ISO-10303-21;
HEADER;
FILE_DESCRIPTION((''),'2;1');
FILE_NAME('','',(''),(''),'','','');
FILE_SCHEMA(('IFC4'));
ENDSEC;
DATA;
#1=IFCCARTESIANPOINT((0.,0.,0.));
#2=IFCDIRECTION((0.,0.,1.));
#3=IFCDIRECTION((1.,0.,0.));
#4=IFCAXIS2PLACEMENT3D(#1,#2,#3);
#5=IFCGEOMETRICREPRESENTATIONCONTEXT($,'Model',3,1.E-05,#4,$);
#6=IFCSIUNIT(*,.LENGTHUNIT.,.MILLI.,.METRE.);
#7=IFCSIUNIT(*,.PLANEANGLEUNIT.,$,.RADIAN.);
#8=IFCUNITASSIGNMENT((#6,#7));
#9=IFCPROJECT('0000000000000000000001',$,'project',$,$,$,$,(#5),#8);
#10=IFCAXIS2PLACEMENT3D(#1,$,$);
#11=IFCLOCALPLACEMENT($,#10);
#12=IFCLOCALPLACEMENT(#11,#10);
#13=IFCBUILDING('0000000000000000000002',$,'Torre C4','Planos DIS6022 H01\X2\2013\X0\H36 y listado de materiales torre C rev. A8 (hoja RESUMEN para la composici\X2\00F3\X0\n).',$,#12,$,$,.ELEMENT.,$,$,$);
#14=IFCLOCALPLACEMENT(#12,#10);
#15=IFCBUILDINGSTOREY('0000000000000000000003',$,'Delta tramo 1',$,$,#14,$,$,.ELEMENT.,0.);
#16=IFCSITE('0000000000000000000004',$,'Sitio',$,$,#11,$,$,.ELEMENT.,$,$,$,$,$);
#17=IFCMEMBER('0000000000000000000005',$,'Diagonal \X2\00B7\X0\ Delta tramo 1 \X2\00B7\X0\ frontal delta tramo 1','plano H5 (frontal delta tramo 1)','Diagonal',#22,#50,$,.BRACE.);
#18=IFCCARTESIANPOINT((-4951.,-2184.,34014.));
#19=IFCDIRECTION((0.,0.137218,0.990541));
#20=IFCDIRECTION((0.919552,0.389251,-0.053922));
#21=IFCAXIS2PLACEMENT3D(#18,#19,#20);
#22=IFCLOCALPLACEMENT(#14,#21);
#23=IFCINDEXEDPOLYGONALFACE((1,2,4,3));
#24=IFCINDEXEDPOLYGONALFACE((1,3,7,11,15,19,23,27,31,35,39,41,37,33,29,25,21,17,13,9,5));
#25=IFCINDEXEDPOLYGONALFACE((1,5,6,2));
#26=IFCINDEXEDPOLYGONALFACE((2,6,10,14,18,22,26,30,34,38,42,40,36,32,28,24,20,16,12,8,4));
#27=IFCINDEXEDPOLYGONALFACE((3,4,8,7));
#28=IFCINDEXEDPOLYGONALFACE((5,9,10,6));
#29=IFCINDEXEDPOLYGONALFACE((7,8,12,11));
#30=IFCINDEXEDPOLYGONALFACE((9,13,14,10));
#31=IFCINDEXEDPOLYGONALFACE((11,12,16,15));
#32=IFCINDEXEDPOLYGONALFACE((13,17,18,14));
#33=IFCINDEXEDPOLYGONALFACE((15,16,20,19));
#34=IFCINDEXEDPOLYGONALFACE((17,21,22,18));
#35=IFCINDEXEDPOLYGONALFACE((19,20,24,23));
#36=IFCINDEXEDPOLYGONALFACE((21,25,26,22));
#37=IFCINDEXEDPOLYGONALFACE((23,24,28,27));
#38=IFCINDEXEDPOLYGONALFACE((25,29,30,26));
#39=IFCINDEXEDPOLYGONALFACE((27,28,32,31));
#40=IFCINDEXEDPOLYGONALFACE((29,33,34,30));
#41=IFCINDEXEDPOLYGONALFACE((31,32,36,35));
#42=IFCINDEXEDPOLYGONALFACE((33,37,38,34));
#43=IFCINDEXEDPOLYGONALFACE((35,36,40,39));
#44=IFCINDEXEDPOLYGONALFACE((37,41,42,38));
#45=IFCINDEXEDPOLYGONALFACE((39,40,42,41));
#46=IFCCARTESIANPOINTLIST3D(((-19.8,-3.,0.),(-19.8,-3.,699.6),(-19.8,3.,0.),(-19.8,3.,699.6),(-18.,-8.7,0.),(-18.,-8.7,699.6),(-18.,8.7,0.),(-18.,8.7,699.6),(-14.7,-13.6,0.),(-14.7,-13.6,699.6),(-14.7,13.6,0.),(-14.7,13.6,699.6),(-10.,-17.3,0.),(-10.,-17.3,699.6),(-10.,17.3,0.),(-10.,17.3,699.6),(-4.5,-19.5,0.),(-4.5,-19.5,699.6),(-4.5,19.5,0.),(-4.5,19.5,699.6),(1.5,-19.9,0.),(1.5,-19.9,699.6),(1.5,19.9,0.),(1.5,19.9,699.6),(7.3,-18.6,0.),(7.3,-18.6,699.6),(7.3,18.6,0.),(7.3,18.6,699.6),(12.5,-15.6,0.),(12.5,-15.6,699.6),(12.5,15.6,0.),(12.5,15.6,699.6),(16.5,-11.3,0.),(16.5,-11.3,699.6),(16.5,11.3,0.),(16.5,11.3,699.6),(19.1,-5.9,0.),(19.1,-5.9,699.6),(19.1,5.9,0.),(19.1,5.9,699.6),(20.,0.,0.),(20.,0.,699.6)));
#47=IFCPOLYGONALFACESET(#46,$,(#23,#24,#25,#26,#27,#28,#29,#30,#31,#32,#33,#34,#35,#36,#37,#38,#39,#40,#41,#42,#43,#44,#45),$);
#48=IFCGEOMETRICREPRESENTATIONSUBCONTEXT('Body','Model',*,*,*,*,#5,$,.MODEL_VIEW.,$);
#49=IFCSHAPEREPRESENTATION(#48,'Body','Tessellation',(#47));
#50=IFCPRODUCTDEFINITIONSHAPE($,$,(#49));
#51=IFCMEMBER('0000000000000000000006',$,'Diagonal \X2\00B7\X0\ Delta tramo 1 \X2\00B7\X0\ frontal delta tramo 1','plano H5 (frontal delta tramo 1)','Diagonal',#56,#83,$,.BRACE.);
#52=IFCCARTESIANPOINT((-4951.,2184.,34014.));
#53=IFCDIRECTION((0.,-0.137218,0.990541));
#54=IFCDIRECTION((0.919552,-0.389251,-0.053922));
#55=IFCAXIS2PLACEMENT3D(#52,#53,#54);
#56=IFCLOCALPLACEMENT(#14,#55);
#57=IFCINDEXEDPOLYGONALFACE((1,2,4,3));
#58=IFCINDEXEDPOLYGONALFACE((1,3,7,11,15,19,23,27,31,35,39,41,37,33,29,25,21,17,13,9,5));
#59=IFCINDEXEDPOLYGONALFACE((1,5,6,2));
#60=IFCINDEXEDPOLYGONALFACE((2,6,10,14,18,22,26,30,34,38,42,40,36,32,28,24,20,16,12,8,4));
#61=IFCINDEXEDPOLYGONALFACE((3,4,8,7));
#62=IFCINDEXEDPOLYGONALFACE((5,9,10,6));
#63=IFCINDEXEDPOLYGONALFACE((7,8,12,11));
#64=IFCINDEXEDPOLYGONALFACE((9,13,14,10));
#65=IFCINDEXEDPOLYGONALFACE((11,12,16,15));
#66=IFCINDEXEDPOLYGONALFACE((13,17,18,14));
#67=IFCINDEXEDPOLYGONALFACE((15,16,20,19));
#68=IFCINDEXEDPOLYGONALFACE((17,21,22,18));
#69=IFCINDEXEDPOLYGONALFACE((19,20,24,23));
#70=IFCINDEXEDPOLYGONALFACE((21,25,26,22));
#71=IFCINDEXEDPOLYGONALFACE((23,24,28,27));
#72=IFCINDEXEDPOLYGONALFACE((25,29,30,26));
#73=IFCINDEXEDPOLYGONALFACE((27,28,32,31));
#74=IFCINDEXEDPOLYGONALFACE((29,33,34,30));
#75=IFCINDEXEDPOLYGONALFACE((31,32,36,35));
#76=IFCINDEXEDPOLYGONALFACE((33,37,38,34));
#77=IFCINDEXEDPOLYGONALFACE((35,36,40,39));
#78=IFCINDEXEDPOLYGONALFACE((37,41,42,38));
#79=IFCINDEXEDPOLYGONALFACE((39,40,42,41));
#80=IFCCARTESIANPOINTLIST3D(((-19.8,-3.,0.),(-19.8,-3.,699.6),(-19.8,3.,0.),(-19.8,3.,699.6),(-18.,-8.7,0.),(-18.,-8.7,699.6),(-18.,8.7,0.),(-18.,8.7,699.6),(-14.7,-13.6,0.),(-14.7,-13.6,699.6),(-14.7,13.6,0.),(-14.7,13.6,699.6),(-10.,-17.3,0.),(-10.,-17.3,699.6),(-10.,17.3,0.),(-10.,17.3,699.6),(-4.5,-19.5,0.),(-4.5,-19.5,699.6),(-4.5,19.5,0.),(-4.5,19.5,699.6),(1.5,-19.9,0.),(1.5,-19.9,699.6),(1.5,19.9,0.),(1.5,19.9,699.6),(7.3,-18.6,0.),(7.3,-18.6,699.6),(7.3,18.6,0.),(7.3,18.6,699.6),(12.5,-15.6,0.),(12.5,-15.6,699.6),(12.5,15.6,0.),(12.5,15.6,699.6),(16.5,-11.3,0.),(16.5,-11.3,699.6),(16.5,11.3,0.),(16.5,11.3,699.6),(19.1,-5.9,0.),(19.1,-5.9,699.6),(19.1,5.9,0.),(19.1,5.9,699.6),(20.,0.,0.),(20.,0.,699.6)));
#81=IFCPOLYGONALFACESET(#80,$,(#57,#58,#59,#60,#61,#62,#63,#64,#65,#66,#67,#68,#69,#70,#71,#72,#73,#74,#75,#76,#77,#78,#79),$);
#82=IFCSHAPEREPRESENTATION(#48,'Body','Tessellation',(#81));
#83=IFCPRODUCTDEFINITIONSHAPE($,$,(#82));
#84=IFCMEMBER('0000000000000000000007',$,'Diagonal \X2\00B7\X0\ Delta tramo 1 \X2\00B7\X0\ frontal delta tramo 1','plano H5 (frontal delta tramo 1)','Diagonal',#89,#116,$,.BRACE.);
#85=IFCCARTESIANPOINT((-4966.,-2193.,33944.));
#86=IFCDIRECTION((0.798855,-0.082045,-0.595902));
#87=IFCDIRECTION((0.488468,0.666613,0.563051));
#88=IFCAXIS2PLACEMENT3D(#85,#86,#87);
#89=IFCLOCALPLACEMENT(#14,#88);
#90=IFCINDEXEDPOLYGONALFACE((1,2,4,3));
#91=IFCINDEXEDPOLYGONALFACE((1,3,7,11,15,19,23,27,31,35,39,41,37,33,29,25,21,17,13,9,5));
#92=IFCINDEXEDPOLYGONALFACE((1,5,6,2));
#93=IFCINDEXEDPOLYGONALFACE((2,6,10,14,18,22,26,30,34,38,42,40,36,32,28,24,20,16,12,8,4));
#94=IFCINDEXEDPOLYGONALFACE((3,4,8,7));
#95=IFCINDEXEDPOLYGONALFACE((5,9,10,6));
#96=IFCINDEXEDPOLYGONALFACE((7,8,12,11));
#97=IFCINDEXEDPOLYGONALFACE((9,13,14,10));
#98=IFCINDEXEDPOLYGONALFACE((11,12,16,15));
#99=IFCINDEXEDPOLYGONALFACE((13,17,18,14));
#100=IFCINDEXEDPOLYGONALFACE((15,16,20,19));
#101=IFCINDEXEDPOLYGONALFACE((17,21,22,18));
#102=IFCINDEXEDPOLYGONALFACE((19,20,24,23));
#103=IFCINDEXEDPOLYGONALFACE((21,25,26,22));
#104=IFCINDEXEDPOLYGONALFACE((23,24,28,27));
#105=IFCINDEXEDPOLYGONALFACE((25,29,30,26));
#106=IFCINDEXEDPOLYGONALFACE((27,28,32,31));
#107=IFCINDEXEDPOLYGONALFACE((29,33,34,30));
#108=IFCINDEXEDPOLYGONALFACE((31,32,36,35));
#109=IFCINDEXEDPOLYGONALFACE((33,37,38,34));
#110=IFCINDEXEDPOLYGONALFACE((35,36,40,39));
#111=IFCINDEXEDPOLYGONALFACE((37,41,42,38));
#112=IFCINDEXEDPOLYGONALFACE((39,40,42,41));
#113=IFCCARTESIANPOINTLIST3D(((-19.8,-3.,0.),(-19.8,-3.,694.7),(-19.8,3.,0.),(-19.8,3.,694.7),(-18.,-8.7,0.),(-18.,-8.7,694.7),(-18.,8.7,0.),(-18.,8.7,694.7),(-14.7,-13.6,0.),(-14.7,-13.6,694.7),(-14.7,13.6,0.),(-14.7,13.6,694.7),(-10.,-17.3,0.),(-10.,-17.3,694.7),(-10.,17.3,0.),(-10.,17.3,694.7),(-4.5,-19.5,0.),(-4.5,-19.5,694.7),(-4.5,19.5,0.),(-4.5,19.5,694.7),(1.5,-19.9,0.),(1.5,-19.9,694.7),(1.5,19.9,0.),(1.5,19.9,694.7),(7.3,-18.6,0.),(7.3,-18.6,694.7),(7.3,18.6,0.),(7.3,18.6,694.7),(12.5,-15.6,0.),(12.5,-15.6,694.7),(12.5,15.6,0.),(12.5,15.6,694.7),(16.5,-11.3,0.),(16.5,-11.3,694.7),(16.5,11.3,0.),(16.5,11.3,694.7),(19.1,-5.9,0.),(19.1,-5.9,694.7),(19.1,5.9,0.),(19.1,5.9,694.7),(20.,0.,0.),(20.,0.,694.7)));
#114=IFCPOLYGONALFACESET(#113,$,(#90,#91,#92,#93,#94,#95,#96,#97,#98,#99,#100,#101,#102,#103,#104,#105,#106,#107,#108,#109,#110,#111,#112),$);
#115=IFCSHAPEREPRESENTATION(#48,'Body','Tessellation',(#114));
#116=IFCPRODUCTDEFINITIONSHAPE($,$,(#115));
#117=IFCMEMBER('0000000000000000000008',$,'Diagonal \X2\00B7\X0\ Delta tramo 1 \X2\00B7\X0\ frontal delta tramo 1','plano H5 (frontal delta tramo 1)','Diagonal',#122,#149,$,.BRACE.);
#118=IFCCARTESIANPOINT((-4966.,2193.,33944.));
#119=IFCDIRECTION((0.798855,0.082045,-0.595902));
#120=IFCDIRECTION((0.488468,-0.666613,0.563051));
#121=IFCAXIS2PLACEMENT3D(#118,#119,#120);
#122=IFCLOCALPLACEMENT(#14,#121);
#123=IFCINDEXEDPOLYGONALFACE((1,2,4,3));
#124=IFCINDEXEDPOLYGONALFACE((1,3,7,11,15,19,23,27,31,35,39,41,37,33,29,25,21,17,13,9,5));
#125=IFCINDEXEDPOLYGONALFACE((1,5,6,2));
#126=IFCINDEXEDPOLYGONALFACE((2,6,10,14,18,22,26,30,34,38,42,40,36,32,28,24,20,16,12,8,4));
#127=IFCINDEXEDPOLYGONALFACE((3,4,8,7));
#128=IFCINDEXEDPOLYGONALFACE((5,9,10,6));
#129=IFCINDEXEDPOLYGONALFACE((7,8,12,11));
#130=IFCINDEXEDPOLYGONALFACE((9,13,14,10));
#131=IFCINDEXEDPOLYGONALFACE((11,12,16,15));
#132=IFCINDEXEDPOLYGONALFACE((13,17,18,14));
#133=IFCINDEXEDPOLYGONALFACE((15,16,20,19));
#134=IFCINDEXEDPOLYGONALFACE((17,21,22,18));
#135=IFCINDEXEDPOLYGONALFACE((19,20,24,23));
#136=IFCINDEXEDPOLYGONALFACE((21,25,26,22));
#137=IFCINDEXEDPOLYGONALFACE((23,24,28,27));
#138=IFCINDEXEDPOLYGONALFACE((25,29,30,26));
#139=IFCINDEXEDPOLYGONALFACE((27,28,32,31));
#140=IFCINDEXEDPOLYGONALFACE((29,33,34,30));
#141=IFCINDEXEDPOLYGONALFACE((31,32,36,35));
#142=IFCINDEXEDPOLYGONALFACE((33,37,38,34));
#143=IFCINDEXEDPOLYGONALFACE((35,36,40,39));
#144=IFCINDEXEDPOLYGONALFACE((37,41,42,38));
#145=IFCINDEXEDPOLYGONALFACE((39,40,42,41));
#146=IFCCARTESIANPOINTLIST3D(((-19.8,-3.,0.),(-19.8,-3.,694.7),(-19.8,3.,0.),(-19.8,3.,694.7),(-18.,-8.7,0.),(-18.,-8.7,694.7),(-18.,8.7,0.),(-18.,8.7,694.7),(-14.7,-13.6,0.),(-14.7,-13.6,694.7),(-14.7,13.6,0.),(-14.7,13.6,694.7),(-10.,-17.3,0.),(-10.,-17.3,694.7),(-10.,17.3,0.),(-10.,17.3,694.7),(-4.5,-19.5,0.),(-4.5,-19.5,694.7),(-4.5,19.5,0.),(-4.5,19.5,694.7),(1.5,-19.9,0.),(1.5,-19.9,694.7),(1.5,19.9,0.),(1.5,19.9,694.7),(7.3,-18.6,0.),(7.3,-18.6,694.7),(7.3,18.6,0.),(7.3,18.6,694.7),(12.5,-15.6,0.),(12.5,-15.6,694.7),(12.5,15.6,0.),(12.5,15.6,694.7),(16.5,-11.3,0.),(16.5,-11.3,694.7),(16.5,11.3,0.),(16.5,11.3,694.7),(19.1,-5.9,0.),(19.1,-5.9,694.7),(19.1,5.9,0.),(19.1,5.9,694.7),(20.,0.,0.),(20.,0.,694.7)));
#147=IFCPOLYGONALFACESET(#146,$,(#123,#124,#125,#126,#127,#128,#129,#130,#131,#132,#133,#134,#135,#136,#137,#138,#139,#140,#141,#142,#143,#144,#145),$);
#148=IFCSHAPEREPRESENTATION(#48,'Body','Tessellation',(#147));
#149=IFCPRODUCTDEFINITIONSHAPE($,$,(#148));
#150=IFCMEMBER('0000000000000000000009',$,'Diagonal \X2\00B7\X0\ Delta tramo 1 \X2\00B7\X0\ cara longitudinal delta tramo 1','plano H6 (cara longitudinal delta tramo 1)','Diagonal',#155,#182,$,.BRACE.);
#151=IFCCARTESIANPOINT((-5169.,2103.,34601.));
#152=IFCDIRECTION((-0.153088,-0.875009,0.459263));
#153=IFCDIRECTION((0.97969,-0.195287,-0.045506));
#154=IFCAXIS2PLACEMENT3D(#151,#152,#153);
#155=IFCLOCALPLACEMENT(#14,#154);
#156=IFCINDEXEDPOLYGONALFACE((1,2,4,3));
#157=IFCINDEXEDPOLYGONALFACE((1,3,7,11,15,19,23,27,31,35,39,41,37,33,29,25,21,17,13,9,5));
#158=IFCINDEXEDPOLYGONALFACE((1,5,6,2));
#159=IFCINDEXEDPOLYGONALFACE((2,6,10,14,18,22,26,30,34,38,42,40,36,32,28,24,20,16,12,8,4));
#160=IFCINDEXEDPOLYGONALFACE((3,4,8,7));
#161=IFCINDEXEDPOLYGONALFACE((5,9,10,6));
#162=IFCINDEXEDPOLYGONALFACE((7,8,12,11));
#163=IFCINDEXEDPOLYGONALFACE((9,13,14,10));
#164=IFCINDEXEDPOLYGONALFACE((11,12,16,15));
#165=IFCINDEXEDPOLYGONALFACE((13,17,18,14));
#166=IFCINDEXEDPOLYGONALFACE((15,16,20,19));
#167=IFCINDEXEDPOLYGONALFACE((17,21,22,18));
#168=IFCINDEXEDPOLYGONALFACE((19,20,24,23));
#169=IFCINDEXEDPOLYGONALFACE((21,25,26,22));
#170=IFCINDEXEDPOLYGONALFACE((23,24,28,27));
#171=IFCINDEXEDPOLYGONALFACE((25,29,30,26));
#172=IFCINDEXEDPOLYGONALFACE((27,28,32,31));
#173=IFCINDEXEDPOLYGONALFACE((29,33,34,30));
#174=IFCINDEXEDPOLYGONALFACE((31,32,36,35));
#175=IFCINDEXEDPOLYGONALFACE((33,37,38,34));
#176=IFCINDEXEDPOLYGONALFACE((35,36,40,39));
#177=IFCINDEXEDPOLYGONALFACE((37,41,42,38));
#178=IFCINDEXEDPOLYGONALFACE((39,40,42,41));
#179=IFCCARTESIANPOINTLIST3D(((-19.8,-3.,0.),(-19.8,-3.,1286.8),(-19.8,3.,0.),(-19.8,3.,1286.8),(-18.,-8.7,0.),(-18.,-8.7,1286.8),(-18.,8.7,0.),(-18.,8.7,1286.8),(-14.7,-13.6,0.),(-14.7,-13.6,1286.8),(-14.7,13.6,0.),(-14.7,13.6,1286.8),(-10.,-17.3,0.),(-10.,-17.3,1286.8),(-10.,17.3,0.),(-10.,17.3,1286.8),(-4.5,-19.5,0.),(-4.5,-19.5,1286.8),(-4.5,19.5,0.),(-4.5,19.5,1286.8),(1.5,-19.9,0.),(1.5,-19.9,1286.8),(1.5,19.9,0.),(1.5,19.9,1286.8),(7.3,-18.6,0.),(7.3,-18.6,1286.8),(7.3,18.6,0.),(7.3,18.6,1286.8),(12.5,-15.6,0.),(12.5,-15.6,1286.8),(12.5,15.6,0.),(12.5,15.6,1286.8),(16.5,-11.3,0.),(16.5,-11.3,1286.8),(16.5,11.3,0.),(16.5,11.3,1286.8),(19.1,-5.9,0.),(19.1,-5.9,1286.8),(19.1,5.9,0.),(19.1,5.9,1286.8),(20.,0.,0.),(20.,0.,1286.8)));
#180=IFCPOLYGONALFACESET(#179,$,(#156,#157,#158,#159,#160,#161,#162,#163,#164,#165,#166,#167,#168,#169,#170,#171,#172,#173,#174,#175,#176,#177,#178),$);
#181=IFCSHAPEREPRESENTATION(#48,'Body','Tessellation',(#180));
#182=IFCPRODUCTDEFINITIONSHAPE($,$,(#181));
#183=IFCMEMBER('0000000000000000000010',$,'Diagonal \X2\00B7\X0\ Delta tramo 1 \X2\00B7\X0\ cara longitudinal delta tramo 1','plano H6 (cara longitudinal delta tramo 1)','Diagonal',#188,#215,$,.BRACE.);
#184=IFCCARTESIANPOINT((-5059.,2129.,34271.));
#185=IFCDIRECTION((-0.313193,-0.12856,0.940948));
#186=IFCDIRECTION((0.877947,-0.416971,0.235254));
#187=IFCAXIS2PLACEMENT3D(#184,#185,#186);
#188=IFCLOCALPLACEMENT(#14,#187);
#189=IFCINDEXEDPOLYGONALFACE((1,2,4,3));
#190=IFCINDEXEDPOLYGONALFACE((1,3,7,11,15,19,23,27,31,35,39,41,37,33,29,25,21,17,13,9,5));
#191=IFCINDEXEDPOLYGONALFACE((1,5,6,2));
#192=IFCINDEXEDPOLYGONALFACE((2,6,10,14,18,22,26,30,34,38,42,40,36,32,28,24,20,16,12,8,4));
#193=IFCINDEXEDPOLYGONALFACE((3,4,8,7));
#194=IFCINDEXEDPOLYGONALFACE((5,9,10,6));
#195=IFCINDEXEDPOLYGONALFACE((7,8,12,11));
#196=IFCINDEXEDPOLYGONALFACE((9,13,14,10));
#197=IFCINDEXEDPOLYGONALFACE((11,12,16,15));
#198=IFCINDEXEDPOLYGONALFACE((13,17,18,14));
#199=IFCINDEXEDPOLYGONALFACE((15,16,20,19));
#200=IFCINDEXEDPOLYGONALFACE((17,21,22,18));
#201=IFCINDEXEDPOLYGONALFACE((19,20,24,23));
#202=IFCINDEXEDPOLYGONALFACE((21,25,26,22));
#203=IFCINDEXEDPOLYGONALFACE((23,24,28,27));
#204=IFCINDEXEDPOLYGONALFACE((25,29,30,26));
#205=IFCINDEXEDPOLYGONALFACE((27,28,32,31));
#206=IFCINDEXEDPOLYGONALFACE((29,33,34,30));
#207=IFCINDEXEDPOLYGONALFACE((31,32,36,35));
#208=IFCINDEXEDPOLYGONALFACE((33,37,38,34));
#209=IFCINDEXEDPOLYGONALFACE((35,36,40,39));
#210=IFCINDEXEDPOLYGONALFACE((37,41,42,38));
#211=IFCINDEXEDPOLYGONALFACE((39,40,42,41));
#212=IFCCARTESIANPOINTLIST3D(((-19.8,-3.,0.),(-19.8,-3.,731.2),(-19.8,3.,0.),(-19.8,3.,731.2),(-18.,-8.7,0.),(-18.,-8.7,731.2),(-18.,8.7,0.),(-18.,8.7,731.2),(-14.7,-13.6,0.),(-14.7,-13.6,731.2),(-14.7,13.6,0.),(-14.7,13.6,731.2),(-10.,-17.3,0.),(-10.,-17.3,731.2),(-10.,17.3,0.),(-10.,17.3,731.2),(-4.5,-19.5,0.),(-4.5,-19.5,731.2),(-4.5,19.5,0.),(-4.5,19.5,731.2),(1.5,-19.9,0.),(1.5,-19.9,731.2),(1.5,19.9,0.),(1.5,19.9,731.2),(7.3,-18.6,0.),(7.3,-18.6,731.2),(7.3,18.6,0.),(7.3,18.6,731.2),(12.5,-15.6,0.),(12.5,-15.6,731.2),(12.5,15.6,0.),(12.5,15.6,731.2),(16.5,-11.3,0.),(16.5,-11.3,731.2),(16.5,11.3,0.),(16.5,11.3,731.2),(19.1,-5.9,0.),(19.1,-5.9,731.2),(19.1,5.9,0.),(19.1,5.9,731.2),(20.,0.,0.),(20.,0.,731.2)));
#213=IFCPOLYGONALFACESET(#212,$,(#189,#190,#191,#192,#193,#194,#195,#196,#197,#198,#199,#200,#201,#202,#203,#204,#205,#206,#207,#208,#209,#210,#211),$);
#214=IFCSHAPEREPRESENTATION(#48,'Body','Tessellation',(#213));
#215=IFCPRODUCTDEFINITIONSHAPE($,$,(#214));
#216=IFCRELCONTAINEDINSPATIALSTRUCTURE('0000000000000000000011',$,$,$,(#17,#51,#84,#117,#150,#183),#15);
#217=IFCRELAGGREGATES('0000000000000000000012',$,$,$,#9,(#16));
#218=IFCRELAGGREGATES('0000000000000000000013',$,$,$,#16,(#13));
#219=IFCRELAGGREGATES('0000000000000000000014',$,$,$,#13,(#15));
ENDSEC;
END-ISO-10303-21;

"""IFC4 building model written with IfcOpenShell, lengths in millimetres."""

from ifc_helpers import new_model, si_unit, frame, origin, origin_with_axes, place, context, subcontext, project, spatial, circle, extrude, element, save


model = new_model("IFC4")

# Units and contexts
model_context = context("Model", 3, precision=1e-05, world=origin_with_axes())
body_context = subcontext(model_context, "Body", "Model", "MODEL_VIEW")
ifc_project = project(units=[si_unit("LENGTHUNIT", "METRE", prefix="MILLI"), si_unit("PLANEANGLEUNIT", "RADIAN")], contexts=[model_context])

# Site, building, storey
site_placement = place(None, origin())
site = spatial("IfcSite", under=ifc_project, at=site_placement, Name="Sitio", CompositionType="ELEMENT")
building_placement = place(site_placement, origin())
building = spatial("IfcBuilding", under=site, at=building_placement, Name="Torre C4", Description="Planos DIS6022 H01–H36 y listado de materiales torre C rev. A8 (hoja RESUMEN para la composición).", CompositionType="ELEMENT")
storey_placement = place(building_placement, origin())
storey = spatial("IfcBuildingStorey", under=building, at=storey_placement, Name="Delta tramo 1", CompositionType="ELEMENT", Elevation=0.0)

# Members
for number, where, z_axis, x_axis, name in (
    (1, (-4951.0, -2184.0, 34014.0), (0.0, 0.137218, 0.990541), (0.919552, 0.389251, -0.053922), "Diagonal · Delta tramo 1 · frontal delta tramo 1"),
    (2, (-4951.0, 2184.0, 34014.0), (0.0, -0.137218, 0.990541), (0.919552, -0.389251, -0.053922), "Diagonal · Delta tramo 1 · frontal delta tramo 1"),
):
    element("IfcMember", number, at=place(storey_placement, frame(where, z_axis=z_axis, x_axis=x_axis)), inside=storey, Name=name, Description="plano H5 (frontal delta tramo 1)", ObjectType="Diagonal", PredefinedType="BRACE", context=body_context, shape_type="SweptSolid", body=[
        extrude(circle(Radius=20.0), None, (0.0, 0.0, 1.0), 699.6),
    ])
for number, where, z_axis, x_axis, name in (
    (3, (-4966.0, -2193.0, 33944.0), (0.798855, -0.082045, -0.595902), (0.488468, 0.666613, 0.563051), "Diagonal · Delta tramo 1 · frontal delta tramo 1"),
    (4, (-4966.0, 2193.0, 33944.0), (0.798855, 0.082045, -0.595902), (0.488468, -0.666613, 0.563051), "Diagonal · Delta tramo 1 · frontal delta tramo 1"),
):
    element("IfcMember", number, at=place(storey_placement, frame(where, z_axis=z_axis, x_axis=x_axis)), inside=storey, Name=name, Description="plano H5 (frontal delta tramo 1)", ObjectType="Diagonal", PredefinedType="BRACE", context=body_context, shape_type="SweptSolid", body=[
        extrude(circle(Radius=20.0), None, (0.0, 0.0, 1.0), 694.7),
    ])
member_1_placement = place(storey_placement, frame((-5169.0, 2103.0, 34601.0), z_axis=(-0.153088, -0.875009, 0.459263), x_axis=(0.97969, -0.195287, -0.045506)))
element("IfcMember", 5, at=member_1_placement, inside=storey, Name="Diagonal · Delta tramo 1 · cara longitudinal delta tramo 1", Description="plano H6 (cara longitudinal delta tramo 1)", ObjectType="Diagonal", PredefinedType="BRACE", context=body_context, shape_type="SweptSolid", body=[
    extrude(circle(Radius=20.0), None, (0.0, 0.0, 1.0), 1286.8),
])
member_2_placement = place(storey_placement, frame((-5059.0, 2129.0, 34271.0), z_axis=(-0.313193, -0.12856, 0.940948), x_axis=(0.877947, -0.416971, 0.235254)))
element("IfcMember", 6, at=member_2_placement, inside=storey, Name="Diagonal · Delta tramo 1 · cara longitudinal delta tramo 1", Description="plano H6 (cara longitudinal delta tramo 1)", ObjectType="Diagonal", PredefinedType="BRACE", context=body_context, shape_type="SweptSolid", body=[
    extrude(circle(Radius=20.0), None, (0.0, 0.0, 1.0), 731.2),
])

save(model, "model.ifc")
